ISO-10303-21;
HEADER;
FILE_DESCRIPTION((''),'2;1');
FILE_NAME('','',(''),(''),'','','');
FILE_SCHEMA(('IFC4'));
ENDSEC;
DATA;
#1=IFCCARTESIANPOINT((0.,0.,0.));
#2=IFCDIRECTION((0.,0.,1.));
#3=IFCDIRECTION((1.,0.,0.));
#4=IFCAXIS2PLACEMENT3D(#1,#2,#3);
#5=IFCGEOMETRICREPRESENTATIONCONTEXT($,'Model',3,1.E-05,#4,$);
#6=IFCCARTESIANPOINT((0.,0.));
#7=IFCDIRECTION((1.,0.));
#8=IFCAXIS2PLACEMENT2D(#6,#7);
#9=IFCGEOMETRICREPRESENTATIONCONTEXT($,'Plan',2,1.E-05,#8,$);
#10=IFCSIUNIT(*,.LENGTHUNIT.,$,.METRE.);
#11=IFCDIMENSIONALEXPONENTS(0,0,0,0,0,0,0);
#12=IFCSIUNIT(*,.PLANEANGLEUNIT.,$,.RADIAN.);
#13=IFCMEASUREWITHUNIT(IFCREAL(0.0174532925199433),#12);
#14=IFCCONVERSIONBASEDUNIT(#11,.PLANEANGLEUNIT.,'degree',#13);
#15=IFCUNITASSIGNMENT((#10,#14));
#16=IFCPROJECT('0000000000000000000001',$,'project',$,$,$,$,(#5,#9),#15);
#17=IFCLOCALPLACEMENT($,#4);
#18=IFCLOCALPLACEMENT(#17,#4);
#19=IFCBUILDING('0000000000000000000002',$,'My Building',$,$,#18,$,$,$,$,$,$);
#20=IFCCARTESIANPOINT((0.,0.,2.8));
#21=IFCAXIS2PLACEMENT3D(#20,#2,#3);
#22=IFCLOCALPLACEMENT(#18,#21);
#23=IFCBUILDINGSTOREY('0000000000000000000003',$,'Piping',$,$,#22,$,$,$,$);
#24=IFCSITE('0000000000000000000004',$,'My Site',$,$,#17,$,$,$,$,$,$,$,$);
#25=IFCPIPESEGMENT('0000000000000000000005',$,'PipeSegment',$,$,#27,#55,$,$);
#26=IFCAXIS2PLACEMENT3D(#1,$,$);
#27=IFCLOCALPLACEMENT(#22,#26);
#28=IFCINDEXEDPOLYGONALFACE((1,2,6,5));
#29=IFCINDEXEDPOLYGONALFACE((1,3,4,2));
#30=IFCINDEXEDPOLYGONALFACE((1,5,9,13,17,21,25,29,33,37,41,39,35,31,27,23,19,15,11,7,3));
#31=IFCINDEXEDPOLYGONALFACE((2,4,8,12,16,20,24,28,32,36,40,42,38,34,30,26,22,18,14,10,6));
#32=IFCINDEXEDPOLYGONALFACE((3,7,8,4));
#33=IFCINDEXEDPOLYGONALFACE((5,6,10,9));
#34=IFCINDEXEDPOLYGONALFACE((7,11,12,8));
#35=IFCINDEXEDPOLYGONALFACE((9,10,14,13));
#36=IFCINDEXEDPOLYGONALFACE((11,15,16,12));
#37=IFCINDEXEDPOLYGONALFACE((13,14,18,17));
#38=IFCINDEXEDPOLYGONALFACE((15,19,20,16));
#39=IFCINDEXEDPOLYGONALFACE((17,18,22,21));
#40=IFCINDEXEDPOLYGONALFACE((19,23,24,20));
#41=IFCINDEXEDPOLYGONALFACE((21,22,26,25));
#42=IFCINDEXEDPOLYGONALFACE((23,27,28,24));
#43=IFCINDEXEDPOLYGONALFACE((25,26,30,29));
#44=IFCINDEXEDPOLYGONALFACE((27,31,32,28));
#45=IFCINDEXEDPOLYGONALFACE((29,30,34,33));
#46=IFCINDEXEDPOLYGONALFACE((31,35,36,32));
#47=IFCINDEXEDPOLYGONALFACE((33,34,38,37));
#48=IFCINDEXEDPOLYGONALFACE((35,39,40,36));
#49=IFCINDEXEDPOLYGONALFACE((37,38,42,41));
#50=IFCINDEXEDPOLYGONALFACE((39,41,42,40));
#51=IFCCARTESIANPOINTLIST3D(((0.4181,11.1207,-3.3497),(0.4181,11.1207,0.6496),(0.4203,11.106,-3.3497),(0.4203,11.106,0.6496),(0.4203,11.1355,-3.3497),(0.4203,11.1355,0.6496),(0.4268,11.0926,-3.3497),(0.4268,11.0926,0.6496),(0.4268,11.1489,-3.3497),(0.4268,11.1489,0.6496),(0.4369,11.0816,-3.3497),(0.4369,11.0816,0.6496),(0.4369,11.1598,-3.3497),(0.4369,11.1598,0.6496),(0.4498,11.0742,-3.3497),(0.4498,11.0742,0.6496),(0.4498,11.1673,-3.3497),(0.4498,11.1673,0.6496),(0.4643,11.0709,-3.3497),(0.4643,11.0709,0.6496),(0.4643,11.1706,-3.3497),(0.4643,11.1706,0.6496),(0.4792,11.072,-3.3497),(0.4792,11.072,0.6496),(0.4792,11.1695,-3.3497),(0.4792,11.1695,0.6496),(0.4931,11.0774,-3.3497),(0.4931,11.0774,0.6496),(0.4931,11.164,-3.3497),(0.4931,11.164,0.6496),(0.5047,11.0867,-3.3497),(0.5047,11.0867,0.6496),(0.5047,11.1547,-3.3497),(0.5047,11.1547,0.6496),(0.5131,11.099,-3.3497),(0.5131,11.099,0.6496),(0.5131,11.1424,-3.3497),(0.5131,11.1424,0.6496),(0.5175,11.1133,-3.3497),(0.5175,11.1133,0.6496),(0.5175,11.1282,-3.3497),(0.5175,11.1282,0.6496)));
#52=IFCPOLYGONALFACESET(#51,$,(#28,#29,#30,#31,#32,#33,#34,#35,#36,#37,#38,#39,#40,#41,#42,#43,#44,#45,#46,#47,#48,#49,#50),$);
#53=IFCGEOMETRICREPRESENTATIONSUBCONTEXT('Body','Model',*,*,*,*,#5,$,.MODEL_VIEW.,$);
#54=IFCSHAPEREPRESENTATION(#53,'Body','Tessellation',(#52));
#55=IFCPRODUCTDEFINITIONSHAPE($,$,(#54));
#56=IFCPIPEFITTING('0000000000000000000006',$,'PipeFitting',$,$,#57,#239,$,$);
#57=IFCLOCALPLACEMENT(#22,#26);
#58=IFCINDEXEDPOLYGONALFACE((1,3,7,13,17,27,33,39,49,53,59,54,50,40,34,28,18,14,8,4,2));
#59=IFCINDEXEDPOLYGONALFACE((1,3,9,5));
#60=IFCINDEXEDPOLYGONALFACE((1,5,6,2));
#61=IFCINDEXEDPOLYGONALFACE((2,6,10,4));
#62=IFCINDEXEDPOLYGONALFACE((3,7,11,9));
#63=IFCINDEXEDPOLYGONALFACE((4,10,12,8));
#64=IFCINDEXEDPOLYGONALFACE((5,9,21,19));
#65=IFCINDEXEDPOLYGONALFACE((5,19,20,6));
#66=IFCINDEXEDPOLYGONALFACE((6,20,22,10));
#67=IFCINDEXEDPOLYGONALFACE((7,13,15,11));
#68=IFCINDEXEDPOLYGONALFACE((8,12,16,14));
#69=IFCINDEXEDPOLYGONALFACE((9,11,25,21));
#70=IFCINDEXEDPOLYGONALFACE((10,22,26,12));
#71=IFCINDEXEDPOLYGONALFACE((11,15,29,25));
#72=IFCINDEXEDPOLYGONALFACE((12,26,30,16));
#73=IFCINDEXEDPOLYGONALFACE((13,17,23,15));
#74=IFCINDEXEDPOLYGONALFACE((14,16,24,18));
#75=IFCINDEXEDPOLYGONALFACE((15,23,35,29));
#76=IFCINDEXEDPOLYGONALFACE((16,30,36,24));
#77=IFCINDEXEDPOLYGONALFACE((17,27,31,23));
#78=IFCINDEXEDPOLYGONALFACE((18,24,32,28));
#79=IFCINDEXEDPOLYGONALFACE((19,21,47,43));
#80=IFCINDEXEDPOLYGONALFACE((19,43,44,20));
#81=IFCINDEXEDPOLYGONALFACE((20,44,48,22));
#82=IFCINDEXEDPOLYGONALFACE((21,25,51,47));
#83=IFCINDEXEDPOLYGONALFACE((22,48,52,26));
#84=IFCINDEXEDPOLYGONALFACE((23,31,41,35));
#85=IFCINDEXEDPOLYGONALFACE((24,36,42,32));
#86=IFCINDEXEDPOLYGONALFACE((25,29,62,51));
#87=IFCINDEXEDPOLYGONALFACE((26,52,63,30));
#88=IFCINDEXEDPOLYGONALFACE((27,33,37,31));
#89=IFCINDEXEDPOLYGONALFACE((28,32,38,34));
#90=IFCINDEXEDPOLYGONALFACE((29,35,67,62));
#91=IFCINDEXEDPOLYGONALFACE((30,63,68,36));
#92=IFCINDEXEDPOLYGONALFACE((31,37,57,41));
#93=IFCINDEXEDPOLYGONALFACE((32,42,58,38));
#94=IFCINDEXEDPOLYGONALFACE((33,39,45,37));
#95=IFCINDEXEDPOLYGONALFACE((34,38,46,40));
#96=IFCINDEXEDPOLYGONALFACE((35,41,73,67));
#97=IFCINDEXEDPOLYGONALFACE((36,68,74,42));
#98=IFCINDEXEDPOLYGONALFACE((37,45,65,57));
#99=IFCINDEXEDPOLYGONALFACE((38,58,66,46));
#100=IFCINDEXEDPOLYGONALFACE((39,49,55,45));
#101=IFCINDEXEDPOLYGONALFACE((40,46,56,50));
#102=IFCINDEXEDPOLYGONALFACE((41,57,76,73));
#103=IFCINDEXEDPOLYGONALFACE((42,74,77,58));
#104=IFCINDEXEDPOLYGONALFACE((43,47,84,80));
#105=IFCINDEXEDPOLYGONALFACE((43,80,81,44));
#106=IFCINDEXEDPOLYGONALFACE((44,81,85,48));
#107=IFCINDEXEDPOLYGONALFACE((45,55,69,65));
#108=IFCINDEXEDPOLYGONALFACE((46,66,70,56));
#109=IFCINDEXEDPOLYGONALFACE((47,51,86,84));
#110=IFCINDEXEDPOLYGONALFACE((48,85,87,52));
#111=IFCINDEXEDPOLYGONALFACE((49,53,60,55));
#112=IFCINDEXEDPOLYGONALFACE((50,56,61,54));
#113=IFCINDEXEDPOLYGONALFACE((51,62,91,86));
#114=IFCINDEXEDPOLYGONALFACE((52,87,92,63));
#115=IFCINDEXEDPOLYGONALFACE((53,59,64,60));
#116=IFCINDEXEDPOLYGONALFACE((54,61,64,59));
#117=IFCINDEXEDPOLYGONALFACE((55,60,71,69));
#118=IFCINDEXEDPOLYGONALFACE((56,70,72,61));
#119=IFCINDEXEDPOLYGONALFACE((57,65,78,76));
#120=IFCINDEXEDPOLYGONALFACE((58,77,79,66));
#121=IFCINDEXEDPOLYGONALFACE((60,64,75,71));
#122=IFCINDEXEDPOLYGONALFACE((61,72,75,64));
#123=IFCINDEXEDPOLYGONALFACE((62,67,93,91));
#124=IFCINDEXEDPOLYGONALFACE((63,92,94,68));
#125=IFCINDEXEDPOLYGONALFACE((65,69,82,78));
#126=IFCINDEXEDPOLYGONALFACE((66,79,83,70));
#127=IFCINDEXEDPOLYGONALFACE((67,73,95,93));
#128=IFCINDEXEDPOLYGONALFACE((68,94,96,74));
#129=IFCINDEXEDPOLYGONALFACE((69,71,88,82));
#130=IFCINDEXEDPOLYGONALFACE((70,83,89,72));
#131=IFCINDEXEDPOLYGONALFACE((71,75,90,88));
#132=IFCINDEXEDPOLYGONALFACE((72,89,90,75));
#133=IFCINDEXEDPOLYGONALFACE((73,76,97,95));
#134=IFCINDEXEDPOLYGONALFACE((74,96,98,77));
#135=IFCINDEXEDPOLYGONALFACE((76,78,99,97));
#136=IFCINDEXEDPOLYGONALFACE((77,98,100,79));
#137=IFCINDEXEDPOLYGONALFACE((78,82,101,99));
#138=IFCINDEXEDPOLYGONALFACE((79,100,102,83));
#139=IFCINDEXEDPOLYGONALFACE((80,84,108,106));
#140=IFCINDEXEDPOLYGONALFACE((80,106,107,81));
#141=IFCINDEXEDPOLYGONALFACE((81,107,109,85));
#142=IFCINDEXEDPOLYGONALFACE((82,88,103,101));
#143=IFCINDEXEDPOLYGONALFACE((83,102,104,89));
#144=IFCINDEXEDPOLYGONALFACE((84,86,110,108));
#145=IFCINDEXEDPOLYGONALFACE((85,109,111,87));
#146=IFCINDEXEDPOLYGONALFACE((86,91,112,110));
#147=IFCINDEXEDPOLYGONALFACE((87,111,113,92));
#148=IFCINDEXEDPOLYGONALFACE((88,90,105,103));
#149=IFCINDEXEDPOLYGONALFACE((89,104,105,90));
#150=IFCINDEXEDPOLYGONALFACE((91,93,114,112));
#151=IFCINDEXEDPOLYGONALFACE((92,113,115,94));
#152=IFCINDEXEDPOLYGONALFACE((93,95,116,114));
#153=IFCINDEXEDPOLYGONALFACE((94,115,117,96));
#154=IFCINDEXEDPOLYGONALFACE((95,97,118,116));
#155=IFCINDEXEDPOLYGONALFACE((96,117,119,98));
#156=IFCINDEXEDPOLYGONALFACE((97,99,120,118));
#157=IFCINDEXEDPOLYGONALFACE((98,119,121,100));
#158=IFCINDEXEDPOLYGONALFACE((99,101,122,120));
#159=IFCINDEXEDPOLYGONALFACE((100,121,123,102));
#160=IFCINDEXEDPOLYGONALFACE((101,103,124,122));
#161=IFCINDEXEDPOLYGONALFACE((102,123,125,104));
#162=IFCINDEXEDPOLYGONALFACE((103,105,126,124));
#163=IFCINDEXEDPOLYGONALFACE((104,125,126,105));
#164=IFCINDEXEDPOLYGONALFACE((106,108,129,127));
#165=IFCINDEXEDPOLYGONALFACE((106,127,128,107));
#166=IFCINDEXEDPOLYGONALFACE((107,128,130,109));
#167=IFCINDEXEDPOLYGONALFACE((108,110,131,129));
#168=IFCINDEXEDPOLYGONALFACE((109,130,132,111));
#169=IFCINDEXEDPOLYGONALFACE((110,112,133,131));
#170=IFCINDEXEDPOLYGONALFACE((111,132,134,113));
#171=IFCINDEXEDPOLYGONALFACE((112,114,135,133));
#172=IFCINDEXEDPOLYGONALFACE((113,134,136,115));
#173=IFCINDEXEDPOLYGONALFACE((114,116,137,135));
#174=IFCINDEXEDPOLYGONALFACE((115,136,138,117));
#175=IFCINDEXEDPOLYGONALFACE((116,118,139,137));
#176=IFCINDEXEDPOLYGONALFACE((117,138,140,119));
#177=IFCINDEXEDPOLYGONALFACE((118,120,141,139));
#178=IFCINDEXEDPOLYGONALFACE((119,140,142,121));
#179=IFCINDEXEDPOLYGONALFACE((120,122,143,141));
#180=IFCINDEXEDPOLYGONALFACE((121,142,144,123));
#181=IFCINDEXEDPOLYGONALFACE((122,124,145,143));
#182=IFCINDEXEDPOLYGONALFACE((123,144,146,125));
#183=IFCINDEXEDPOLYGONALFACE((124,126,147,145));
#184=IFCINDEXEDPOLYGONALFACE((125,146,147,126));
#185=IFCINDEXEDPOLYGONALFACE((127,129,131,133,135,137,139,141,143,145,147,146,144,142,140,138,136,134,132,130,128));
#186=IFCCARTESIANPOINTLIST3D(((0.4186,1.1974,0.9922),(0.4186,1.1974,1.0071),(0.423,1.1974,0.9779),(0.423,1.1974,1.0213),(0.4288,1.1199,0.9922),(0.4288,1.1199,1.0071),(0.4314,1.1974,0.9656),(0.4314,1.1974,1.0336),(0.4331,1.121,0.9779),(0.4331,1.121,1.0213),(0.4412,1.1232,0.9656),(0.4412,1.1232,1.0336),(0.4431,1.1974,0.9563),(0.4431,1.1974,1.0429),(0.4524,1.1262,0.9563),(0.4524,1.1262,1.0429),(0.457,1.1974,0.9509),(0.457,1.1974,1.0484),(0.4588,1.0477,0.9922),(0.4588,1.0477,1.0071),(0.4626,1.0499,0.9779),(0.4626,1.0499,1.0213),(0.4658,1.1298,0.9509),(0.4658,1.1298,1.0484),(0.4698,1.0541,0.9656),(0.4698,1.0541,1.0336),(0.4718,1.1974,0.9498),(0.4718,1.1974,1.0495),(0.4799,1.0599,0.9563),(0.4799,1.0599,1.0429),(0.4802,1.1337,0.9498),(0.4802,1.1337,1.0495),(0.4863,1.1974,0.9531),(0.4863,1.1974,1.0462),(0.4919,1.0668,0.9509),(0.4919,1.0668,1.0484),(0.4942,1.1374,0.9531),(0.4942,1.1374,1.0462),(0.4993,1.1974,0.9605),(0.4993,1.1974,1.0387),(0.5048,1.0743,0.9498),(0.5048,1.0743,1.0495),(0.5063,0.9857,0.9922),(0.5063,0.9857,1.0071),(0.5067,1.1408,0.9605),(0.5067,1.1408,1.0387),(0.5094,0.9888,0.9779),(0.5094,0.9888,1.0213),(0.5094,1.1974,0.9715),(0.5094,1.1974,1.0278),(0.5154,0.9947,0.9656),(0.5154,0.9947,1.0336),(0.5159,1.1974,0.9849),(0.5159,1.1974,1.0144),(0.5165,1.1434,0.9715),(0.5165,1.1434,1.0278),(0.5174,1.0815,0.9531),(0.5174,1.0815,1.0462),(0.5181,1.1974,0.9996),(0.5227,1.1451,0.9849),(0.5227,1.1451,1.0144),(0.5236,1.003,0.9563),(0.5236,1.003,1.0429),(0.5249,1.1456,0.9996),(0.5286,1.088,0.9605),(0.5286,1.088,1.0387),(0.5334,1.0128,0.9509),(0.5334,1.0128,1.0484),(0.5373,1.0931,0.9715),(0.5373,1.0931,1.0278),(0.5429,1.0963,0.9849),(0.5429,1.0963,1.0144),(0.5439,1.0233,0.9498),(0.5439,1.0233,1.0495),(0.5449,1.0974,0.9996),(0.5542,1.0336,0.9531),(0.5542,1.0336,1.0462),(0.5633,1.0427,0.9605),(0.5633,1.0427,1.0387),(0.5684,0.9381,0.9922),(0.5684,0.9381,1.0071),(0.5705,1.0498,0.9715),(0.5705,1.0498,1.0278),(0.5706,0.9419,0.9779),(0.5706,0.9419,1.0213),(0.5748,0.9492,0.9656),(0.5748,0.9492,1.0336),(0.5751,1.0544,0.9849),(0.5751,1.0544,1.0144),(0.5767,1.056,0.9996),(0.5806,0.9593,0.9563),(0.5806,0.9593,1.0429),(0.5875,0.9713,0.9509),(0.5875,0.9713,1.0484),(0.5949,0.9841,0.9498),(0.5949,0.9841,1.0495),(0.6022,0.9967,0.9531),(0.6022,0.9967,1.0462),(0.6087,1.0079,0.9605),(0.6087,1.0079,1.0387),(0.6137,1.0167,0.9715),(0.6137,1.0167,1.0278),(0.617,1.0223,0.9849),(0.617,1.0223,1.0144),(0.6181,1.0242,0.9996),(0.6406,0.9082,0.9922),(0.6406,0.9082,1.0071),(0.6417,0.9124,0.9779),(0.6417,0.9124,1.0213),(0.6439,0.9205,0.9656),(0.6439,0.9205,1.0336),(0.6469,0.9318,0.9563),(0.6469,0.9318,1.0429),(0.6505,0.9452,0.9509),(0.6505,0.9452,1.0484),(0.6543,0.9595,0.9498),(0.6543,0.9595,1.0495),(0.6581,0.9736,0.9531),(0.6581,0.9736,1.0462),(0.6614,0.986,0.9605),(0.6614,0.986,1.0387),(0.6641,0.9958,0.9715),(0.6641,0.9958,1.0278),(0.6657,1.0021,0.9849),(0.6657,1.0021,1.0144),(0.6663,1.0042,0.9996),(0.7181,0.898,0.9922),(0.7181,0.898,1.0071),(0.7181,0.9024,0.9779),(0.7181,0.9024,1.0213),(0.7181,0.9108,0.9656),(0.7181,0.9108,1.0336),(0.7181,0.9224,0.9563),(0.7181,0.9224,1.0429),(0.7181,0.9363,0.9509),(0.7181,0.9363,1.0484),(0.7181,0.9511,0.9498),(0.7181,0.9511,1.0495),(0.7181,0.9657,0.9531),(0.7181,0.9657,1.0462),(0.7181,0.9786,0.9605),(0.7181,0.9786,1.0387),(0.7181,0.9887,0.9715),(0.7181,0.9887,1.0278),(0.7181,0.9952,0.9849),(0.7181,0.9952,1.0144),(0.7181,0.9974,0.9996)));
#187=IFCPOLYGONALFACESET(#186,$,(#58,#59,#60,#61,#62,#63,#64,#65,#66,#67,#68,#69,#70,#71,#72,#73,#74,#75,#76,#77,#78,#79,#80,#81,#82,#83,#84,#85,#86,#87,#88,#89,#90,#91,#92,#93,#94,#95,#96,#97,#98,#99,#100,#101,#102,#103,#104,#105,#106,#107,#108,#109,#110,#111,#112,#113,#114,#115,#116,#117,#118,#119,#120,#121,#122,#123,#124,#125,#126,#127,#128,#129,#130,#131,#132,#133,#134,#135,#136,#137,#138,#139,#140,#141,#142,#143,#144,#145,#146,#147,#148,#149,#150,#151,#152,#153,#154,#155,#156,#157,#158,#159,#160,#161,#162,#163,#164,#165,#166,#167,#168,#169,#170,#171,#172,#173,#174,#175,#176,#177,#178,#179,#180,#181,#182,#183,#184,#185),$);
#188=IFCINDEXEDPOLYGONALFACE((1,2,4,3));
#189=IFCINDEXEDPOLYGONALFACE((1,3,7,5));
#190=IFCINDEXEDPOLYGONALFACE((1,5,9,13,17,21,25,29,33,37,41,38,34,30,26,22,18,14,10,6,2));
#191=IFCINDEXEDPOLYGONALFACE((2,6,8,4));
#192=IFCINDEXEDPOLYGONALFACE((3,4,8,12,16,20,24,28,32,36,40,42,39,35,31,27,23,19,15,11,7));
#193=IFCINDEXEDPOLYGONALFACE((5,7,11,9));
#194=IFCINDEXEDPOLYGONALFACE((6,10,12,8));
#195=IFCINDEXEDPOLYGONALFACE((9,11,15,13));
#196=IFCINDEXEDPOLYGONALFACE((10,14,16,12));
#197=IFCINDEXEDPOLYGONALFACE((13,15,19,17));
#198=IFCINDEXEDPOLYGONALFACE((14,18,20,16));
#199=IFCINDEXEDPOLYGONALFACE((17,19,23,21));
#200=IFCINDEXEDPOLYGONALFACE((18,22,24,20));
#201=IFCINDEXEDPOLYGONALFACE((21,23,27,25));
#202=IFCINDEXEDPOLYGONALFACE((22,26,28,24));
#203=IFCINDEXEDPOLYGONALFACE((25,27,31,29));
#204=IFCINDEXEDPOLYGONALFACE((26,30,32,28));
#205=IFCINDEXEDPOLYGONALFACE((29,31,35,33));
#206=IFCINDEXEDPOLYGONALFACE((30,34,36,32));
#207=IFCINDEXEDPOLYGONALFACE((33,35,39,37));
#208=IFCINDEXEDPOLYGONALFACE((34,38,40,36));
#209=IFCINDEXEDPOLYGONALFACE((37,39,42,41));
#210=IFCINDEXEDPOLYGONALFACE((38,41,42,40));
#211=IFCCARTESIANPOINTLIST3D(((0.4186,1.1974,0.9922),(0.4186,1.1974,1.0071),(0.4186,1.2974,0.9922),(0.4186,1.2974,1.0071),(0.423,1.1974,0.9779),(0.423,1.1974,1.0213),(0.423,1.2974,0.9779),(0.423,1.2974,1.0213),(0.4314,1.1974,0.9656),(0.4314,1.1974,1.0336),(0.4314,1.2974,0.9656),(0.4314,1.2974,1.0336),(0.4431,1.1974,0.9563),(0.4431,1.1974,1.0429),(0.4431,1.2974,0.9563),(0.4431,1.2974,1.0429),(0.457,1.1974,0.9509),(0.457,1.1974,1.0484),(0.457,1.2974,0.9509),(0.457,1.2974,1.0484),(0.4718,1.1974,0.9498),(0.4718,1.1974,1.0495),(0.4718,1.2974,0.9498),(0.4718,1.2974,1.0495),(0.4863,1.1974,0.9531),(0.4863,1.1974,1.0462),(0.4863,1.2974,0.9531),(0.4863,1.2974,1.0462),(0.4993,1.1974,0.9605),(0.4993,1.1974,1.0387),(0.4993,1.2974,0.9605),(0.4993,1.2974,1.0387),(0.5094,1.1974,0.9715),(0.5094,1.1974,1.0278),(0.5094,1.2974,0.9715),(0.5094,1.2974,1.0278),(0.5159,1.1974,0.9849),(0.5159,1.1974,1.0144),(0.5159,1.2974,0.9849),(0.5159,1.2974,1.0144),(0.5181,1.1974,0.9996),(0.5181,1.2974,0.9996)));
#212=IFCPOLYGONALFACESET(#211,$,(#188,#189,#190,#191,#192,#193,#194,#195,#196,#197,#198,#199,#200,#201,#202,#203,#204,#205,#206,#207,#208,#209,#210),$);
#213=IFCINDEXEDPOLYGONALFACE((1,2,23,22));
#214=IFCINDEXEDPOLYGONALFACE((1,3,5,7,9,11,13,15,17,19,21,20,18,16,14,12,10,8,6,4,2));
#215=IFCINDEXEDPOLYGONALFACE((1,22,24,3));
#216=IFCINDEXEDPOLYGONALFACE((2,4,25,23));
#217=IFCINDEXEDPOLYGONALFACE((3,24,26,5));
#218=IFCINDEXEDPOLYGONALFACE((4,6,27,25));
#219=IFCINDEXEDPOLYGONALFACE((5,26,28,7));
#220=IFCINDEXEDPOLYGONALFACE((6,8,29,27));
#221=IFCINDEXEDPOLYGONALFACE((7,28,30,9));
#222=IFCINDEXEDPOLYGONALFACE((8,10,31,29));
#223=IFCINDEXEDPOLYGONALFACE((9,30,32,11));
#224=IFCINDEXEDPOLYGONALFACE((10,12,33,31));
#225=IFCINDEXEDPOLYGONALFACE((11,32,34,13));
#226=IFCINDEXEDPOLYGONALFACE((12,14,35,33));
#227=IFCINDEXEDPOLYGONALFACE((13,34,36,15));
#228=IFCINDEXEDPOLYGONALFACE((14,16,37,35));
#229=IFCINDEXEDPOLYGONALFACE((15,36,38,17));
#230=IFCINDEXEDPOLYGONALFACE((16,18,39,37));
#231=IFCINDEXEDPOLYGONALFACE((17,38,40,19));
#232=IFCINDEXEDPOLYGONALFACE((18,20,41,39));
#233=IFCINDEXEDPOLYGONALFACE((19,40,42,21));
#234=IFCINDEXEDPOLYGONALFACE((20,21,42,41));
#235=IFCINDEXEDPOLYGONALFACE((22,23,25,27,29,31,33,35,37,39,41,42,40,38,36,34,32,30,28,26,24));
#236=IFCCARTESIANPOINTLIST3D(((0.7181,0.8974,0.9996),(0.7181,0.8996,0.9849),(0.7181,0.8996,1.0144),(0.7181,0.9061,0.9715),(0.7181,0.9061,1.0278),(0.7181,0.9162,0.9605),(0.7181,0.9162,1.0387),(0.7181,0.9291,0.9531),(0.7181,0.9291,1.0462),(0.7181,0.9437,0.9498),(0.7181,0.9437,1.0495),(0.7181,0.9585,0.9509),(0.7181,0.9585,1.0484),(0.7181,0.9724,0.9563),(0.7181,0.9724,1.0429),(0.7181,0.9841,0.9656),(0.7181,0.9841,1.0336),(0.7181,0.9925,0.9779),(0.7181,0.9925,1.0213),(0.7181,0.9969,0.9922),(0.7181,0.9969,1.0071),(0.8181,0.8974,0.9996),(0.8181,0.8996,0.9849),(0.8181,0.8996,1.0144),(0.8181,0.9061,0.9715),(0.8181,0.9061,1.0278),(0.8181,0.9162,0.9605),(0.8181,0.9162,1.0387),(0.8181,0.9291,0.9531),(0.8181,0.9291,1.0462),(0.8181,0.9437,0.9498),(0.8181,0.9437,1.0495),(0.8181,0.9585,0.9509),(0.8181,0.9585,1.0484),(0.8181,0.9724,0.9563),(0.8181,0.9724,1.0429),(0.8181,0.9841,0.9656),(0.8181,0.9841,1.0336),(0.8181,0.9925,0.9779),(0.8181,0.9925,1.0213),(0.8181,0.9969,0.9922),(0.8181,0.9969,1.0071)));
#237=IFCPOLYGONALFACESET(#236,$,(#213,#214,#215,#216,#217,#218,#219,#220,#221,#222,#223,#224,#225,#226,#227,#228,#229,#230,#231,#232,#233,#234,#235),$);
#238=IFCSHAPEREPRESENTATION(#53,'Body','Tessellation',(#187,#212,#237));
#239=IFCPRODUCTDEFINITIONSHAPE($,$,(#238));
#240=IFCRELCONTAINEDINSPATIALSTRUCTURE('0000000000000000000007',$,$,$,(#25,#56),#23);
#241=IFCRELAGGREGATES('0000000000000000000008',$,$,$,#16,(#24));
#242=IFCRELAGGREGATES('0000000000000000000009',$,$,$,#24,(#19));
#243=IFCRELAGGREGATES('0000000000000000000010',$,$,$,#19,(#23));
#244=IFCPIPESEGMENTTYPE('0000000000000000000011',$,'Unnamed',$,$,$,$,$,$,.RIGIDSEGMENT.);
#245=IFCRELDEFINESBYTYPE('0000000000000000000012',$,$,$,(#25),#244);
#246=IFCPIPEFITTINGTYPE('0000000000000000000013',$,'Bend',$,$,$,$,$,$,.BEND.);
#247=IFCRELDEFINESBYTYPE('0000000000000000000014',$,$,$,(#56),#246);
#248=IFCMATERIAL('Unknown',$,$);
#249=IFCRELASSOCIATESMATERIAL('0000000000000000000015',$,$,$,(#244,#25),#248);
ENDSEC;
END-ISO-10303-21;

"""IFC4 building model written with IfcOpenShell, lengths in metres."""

from ifc_helpers import new_model, entity, si_unit, converted_unit, frame, origin_with_axes, origin_2d_with_axis, place, context, subcontext, project, spatial, circle, extrude, source, transform, mapped, material, material_profile, profile_set, profile_usage, type_object, type_shapes, element, save


model = new_model("IFC4")

# Units and contexts
model_context = context("Model", 3, precision=1e-05, world=origin_with_axes())
plan_context = context("Plan", 2, precision=1e-05, world=origin_2d_with_axis())
body_context = subcontext(model_context, "Body", "Model", "MODEL_VIEW")
ifc_project = project(units=[si_unit("LENGTHUNIT", "METRE"), converted_unit("PLANEANGLEUNIT", "degree", entity("IfcReal", 0.0174532925199433), si_unit("PLANEANGLEUNIT", "RADIAN"), dimensions=[0, 0, 0, 0, 0, 0, 0])], contexts=[model_context, plan_context])

# Site, building, storey
site_placement = place(None, origin_with_axes())
site = spatial("IfcSite", under=ifc_project, at=site_placement, Name="My Site")
building_placement = place(site_placement, origin_with_axes())
building = spatial("IfcBuilding", under=site, at=building_placement, Name="My Building")
storey_placement = place(building_placement, frame((0.0, 0.0, 2.8), z_axis=(0.0, 0.0, 1.0), x_axis=(1.0, 0.0, 0.0)))
storey = spatial("IfcBuildingStorey", under=building, at=storey_placement, Name="Piping")

# Pipe segment
ifc_material = material(Name="Unknown")
ifc_material_profile_1 = material_profile(ifc_material, circle(Radius=0.05))
ifc_profile_set_1 = profile_set([ifc_material_profile_1])
pipe_segment_type = type_object("IfcPipeSegmentType", Name="Unnamed", PredefinedType="RIGIDSEGMENT", material=ifc_profile_set_1)
ifc_profile_usage_1 = profile_usage(ifc_profile_set_1, cardinal=5)
pipe_segment_1_placement = place(storey_placement, frame((0.4681, 11.1207, 0.6496), z_axis=(0.0, 0.0, -1.0), x_axis=(-1.0, 0.0, 0.0)))
element("IfcPipeSegment", 1, at=pipe_segment_1_placement, inside=storey, type_object=pipe_segment_type, material=ifc_profile_usage_1, Name="PipeSegment", context=body_context, shape_type="SweptSolid", body=[
    extrude(circle(Radius=0.05), origin_with_axes(), (0.0, 0.0, 1.0), 3.9993),
])

# Pipe fitting
pipe_fitting_type_1 = type_object("IfcPipeFittingType", Name="Bend", PredefinedType="BEND")
shared_shape = source(origin_with_axes(), body_context, "Body", "SolidModel", [
    entity("IfcSweptDiskSolid", entity("IfcIndexedPolyCurve", entity("IfcCartesianPointList3D", [[0.0, 0.0, 0.1], [0.0732, 0.0, 0.2768], [0.25, 0.0, 0.35]]), [entity("IfcArcIndex", [1, 2, 3])]), 0.05),
    extrude(circle(Radius=0.05), origin_with_axes(), (0.0, 0.0, 1.0), 0.1),
    extrude(circle(Radius=0.05), frame((0.25, 0.0, 0.35), z_axis=(1.0, 0.0, 0.0), x_axis=(0.0, 0.0, 1.0)), (0.0, 0.0, 1.0), 0.1),
])
type_shapes(pipe_fitting_type_1, [shared_shape])
for number, where, z_axis, x_axis, name in (
    (2, (0.4681, 1.2974, 0.9996), (0.0, -1.0, 0.0), (1.0, 0.0, 0.0), "PipeFitting"),
):
    element("IfcPipeFitting", number, at=place(storey_placement, frame(where, z_axis=z_axis, x_axis=x_axis)), inside=storey, type_object=pipe_fitting_type_1, Name=name, context=body_context, shape_type="MappedRepresentation", body=[
        mapped(shared_shape, transform((0.0, 0.0, 0.0), x_axis=(1.0, 0.0, 0.0), y_axis=(0.0, 1.0, 0.0), z_axis=(0.0, 0.0, 1.0), scale=1.0)),
    ])

save(model, "model.ifc")
